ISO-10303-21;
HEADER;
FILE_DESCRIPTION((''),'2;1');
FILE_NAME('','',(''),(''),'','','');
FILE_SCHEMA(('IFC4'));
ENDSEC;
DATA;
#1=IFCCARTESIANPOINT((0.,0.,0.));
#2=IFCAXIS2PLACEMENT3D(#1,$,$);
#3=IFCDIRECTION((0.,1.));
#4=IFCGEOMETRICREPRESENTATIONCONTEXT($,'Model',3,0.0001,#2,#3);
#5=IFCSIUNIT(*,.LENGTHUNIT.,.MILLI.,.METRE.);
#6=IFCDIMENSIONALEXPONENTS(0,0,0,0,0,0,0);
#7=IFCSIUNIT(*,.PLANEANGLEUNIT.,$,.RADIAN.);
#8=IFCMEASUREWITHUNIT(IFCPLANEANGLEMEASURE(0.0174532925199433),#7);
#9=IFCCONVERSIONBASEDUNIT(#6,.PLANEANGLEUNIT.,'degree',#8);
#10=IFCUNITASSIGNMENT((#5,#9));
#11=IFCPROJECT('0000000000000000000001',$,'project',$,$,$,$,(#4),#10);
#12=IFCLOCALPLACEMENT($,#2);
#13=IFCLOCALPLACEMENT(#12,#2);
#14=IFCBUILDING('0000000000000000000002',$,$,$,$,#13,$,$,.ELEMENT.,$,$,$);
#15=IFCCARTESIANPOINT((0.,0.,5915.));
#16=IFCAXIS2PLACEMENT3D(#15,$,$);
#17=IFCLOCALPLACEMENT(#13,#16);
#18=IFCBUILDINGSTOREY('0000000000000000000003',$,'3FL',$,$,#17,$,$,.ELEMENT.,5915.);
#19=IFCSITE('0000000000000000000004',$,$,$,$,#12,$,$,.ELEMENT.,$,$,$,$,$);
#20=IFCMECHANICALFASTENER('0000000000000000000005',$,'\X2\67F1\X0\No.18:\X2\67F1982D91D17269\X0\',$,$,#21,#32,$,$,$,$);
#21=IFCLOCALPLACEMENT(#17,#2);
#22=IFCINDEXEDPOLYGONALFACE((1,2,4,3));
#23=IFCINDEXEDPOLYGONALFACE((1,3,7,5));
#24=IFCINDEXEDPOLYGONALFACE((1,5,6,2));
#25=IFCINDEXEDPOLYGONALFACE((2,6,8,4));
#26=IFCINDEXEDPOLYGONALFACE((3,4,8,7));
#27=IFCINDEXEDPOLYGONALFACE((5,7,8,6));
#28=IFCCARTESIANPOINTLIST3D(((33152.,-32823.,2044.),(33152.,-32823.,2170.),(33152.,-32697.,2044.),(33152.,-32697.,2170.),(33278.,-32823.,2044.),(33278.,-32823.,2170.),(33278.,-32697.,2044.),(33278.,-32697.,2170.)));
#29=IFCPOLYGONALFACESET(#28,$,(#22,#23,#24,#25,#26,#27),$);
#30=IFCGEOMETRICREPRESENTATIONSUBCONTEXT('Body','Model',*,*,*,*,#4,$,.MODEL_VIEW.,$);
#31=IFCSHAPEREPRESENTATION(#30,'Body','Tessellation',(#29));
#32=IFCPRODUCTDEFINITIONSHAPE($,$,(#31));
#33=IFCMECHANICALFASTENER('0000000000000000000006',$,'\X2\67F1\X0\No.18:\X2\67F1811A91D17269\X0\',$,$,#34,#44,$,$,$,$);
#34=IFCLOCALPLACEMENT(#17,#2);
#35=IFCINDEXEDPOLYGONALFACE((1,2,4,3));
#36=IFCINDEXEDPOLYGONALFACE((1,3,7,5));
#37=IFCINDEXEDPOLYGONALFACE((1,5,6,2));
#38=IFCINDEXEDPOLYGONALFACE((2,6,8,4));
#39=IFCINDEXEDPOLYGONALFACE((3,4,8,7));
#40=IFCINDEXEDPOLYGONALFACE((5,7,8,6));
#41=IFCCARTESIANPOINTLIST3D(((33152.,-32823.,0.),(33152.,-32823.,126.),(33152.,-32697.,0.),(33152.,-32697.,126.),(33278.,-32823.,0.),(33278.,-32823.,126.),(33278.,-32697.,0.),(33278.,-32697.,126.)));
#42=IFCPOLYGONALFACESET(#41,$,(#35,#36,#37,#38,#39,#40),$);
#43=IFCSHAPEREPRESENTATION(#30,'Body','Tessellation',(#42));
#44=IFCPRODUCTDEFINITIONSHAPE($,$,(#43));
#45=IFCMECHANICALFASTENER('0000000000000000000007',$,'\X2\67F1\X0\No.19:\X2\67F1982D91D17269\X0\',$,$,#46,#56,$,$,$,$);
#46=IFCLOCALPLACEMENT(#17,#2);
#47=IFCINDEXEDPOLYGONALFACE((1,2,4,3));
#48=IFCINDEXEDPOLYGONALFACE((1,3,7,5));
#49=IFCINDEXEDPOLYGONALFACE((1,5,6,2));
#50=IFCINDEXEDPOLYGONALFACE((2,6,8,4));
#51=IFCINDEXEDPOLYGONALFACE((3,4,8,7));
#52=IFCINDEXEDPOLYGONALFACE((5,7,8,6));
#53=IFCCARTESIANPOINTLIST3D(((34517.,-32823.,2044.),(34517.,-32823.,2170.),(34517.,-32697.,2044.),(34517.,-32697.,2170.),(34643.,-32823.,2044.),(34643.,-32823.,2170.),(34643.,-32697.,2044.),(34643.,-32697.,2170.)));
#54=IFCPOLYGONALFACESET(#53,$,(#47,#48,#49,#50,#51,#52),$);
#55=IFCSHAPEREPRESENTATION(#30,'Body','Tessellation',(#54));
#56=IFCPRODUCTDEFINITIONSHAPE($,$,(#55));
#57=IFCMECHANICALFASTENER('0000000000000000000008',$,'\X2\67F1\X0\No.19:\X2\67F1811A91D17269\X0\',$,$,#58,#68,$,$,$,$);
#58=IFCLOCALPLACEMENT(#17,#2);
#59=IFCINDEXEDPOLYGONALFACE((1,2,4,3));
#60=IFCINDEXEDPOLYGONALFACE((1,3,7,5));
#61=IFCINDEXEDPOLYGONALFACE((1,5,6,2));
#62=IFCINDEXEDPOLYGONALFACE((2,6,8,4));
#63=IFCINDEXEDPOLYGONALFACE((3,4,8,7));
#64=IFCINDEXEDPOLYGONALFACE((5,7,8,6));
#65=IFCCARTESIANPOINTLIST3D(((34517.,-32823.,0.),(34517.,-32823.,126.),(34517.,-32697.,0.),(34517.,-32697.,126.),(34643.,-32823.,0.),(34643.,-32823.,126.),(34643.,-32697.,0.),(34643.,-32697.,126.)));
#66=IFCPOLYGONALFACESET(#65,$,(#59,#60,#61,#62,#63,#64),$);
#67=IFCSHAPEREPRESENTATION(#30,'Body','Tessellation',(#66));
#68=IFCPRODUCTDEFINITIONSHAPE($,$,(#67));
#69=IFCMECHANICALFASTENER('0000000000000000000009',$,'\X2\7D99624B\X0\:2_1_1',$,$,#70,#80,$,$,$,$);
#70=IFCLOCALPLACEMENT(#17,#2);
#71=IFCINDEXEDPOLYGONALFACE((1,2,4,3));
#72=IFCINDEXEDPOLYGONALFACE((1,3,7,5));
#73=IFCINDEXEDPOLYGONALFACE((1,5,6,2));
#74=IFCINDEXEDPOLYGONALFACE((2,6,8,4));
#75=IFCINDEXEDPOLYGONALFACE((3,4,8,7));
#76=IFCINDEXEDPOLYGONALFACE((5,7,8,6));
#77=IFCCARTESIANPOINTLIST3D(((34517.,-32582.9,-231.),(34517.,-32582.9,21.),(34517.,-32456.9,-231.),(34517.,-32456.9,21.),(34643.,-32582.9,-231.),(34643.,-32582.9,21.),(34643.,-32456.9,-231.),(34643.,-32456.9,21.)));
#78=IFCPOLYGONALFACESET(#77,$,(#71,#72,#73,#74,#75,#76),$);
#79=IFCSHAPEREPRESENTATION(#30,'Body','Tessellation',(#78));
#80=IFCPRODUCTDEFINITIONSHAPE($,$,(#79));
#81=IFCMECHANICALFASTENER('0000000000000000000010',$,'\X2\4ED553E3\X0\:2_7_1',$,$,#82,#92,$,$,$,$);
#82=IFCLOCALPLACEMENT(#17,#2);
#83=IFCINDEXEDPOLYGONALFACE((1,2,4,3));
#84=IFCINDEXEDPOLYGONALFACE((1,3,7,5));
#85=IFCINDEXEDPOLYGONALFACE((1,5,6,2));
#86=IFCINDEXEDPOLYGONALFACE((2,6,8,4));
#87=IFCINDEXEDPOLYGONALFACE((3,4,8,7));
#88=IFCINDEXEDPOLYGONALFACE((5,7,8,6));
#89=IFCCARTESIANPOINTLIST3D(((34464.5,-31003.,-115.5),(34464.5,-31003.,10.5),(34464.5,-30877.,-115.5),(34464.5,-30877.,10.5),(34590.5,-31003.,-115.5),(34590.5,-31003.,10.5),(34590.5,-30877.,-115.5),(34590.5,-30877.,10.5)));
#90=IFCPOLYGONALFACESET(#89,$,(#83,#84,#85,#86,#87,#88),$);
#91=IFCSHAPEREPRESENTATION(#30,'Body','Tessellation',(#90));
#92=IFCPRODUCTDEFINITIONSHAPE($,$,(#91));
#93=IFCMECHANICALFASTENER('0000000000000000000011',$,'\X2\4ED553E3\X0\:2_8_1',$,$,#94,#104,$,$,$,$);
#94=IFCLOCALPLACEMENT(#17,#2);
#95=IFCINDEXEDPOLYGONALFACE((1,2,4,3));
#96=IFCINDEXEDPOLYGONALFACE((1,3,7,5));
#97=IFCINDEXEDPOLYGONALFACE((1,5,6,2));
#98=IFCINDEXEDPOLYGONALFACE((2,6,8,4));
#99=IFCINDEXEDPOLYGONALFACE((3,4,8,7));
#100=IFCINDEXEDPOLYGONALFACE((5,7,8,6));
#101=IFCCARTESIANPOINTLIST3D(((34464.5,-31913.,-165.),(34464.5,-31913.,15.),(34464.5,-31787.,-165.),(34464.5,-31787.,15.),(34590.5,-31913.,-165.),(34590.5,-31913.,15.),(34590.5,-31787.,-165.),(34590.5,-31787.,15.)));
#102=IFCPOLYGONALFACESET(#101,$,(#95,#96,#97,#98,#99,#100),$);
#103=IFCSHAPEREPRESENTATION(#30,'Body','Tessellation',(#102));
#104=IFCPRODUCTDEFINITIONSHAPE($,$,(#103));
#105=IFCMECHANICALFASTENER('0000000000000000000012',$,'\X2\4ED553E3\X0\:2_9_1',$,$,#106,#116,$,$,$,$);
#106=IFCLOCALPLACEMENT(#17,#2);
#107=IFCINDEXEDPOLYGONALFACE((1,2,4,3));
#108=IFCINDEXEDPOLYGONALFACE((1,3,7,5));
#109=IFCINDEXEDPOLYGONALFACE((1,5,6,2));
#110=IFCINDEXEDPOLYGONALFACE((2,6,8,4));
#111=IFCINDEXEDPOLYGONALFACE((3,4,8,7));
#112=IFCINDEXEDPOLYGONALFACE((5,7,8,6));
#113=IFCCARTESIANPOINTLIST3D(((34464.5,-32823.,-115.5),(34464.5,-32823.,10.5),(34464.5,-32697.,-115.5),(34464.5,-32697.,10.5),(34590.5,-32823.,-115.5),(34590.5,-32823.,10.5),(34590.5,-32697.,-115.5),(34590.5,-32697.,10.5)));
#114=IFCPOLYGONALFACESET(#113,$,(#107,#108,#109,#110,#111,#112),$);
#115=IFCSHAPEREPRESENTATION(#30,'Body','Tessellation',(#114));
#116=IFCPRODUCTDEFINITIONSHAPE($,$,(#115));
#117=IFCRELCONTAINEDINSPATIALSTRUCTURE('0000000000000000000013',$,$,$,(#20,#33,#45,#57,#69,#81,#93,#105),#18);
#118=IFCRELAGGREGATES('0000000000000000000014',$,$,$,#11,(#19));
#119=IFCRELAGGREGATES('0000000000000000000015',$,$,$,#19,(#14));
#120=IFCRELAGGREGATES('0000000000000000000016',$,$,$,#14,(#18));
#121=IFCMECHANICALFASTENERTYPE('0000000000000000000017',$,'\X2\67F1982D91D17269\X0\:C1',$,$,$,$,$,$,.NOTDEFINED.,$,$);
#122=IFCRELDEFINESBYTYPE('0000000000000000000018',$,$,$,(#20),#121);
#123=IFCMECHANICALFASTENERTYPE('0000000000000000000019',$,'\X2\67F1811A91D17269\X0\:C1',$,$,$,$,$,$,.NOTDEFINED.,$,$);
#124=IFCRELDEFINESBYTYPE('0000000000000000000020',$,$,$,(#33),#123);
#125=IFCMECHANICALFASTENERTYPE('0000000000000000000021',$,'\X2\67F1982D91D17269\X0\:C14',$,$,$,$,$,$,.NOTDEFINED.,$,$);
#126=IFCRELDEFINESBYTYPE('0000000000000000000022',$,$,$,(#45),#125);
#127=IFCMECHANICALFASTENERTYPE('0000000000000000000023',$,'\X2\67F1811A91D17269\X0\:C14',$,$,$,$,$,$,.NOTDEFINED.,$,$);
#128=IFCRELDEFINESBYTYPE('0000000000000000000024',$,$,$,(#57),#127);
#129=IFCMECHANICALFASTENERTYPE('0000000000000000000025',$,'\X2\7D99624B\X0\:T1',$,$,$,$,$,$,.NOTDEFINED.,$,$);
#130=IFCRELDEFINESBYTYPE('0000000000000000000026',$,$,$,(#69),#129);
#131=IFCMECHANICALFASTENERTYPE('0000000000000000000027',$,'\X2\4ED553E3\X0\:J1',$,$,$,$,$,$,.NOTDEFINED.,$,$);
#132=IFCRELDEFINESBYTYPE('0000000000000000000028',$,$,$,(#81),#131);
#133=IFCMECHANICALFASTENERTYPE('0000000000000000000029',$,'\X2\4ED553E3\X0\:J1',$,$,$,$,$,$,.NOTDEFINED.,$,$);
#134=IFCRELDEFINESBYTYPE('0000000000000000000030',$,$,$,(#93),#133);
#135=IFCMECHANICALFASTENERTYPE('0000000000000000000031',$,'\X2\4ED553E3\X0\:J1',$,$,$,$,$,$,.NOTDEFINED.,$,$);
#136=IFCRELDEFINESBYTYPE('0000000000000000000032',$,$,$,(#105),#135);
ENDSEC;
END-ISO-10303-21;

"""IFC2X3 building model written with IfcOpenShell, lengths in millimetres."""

from ifc_helpers import new_model, entity, si_unit, converted_unit, direction, frame, origin, origin_with_axes, origin_2d, place, context, subcontext, project, spatial, rectangle, extrude, type_object, element, save


model = new_model("IFC2X3")

# Units and contexts
model_context = context("Model", 3, precision=0.0001, world=origin(), true_north=direction((0.0, 1.0)))
body_context = subcontext(model_context, "Body", "Model", "MODEL_VIEW")
ifc_project = project(units=[si_unit("LENGTHUNIT", "METRE", prefix="MILLI"), converted_unit("PLANEANGLEUNIT", "degree", entity("IfcPlaneAngleMeasure", 0.0174532925199433), si_unit("PLANEANGLEUNIT", "RADIAN"), dimensions=[0, 0, 0, 0, 0, 0, 0])], contexts=[model_context])

# Site, building, storey
site_placement = place(None, origin())
site = spatial("IfcSite", under=ifc_project, at=site_placement, CompositionType="ELEMENT")
building_placement = place(site_placement, origin())
building = spatial("IfcBuilding", under=site, at=building_placement, CompositionType="ELEMENT")
storey_placement = place(building_placement, frame((0.0, 0.0, 5915.0)))
storey = spatial("IfcBuildingStorey", under=building, at=storey_placement, Name="3FL", CompositionType="ELEMENT", Elevation=5915.0)

# Mechanical fasteners
mechanical_fastener_type_1 = type_object("IfcMechanicalFastenerType", Name="柱頭金物:C1")
mechanical_fastener_1_placement = place(storey_placement, frame((33215.0, -32760.0, 2044.0)))
element("IfcMechanicalFastener", 1, at=mechanical_fastener_1_placement, inside=storey, type_object=mechanical_fastener_type_1, Name="柱No.18:柱頭金物", context=body_context, shape_type="SweptSolid", body=[
    extrude(rectangle(XDim=126.0, YDim=126.0, at=origin_2d()), origin_with_axes(), (0.0, 0.0, 1.0), 126.0),
])
mechanical_fastener_type_2 = type_object("IfcMechanicalFastenerType", Name="柱脚金物:C1")
mechanical_fastener_2_placement = place(storey_placement, frame((33215.0, -32760.0, 0.0)))
element("IfcMechanicalFastener", 2, at=mechanical_fastener_2_placement, inside=storey, type_object=mechanical_fastener_type_2, Name="柱No.18:柱脚金物", context=body_context, shape_type="SweptSolid", body=[
    extrude(rectangle(XDim=126.0, YDim=126.0, at=origin_2d()), origin_with_axes(), (0.0, 0.0, 1.0), 126.0),
])
mechanical_fastener_type_3 = type_object("IfcMechanicalFastenerType", Name="柱頭金物:C14")
mechanical_fastener_3_placement = place(storey_placement, frame((34580.0, -32760.0, 2044.0)))
element("IfcMechanicalFastener", 3, at=mechanical_fastener_3_placement, inside=storey, type_object=mechanical_fastener_type_3, Name="柱No.19:柱頭金物", context=body_context, shape_type="SweptSolid", body=[
    extrude(rectangle(XDim=126.0, YDim=126.0, at=origin_2d()), origin_with_axes(), (0.0, 0.0, 1.0), 126.0),
])
mechanical_fastener_type_4 = type_object("IfcMechanicalFastenerType", Name="柱脚金物:C14")
mechanical_fastener_4_placement = place(storey_placement, frame((34580.0, -32760.0, 0.0)))
element("IfcMechanicalFastener", 4, at=mechanical_fastener_4_placement, inside=storey, type_object=mechanical_fastener_type_4, Name="柱No.19:柱脚金物", context=body_context, shape_type="SweptSolid", body=[
    extrude(rectangle(XDim=126.0, YDim=126.0, at=origin_2d()), origin_with_axes(), (0.0, 0.0, 1.0), 126.0),
])
mechanical_fastener_type_5 = type_object("IfcMechanicalFastenerType", Name="継手:T1")
mechanical_fastener_5_placement = place(storey_placement, frame((34580.0, -32519.9, -231.0)))
element("IfcMechanicalFastener", 5, at=mechanical_fastener_5_placement, inside=storey, type_object=mechanical_fastener_type_5, Name="継手:2_1_1", context=body_context, shape_type="SweptSolid", body=[
    extrude(rectangle(XDim=126.0, YDim=126.0, at=origin_2d()), origin_with_axes(), (0.0, 0.0, 1.0), 252.0),
])
mechanical_fastener_type_6 = type_object("IfcMechanicalFastenerType", Name="仕口:J1")
mechanical_fastener_6_placement = place(storey_placement, frame((34527.5, -30940.0, -115.5)))
element("IfcMechanicalFastener", 6, at=mechanical_fastener_6_placement, inside=storey, type_object=mechanical_fastener_type_6, Name="仕口:2_7_1", context=body_context, shape_type="SweptSolid", body=[
    extrude(rectangle(XDim=126.0, YDim=126.0, at=origin_2d()), origin_with_axes(), (0.0, 0.0, 1.0), 126.0),
])
mechanical_fastener_type_7 = type_object("IfcMechanicalFastenerType", Name="仕口:J1")
mechanical_fastener_7_placement = place(storey_placement, frame((34527.5, -31850.0, -165.0)))
element("IfcMechanicalFastener", 7, at=mechanical_fastener_7_placement, inside=storey, type_object=mechanical_fastener_type_7, Name="仕口:2_8_1", context=body_context, shape_type="SweptSolid", body=[
    extrude(rectangle(XDim=126.0, YDim=126.0, at=origin_2d()), origin_with_axes(), (0.0, 0.0, 1.0), 180.0),
])
mechanical_fastener_type_8 = type_object("IfcMechanicalFastenerType", Name="仕口:J1")
mechanical_fastener_8_placement = place(storey_placement, frame((34527.5, -32760.0, -115.5)))
element("IfcMechanicalFastener", 8, at=mechanical_fastener_8_placement, inside=storey, type_object=mechanical_fastener_type_8, Name="仕口:2_9_1", context=body_context, shape_type="SweptSolid", body=[
    extrude(rectangle(XDim=126.0, YDim=126.0, at=origin_2d()), origin_with_axes(), (0.0, 0.0, 1.0), 126.0),
])

save(model, "model.ifc")
